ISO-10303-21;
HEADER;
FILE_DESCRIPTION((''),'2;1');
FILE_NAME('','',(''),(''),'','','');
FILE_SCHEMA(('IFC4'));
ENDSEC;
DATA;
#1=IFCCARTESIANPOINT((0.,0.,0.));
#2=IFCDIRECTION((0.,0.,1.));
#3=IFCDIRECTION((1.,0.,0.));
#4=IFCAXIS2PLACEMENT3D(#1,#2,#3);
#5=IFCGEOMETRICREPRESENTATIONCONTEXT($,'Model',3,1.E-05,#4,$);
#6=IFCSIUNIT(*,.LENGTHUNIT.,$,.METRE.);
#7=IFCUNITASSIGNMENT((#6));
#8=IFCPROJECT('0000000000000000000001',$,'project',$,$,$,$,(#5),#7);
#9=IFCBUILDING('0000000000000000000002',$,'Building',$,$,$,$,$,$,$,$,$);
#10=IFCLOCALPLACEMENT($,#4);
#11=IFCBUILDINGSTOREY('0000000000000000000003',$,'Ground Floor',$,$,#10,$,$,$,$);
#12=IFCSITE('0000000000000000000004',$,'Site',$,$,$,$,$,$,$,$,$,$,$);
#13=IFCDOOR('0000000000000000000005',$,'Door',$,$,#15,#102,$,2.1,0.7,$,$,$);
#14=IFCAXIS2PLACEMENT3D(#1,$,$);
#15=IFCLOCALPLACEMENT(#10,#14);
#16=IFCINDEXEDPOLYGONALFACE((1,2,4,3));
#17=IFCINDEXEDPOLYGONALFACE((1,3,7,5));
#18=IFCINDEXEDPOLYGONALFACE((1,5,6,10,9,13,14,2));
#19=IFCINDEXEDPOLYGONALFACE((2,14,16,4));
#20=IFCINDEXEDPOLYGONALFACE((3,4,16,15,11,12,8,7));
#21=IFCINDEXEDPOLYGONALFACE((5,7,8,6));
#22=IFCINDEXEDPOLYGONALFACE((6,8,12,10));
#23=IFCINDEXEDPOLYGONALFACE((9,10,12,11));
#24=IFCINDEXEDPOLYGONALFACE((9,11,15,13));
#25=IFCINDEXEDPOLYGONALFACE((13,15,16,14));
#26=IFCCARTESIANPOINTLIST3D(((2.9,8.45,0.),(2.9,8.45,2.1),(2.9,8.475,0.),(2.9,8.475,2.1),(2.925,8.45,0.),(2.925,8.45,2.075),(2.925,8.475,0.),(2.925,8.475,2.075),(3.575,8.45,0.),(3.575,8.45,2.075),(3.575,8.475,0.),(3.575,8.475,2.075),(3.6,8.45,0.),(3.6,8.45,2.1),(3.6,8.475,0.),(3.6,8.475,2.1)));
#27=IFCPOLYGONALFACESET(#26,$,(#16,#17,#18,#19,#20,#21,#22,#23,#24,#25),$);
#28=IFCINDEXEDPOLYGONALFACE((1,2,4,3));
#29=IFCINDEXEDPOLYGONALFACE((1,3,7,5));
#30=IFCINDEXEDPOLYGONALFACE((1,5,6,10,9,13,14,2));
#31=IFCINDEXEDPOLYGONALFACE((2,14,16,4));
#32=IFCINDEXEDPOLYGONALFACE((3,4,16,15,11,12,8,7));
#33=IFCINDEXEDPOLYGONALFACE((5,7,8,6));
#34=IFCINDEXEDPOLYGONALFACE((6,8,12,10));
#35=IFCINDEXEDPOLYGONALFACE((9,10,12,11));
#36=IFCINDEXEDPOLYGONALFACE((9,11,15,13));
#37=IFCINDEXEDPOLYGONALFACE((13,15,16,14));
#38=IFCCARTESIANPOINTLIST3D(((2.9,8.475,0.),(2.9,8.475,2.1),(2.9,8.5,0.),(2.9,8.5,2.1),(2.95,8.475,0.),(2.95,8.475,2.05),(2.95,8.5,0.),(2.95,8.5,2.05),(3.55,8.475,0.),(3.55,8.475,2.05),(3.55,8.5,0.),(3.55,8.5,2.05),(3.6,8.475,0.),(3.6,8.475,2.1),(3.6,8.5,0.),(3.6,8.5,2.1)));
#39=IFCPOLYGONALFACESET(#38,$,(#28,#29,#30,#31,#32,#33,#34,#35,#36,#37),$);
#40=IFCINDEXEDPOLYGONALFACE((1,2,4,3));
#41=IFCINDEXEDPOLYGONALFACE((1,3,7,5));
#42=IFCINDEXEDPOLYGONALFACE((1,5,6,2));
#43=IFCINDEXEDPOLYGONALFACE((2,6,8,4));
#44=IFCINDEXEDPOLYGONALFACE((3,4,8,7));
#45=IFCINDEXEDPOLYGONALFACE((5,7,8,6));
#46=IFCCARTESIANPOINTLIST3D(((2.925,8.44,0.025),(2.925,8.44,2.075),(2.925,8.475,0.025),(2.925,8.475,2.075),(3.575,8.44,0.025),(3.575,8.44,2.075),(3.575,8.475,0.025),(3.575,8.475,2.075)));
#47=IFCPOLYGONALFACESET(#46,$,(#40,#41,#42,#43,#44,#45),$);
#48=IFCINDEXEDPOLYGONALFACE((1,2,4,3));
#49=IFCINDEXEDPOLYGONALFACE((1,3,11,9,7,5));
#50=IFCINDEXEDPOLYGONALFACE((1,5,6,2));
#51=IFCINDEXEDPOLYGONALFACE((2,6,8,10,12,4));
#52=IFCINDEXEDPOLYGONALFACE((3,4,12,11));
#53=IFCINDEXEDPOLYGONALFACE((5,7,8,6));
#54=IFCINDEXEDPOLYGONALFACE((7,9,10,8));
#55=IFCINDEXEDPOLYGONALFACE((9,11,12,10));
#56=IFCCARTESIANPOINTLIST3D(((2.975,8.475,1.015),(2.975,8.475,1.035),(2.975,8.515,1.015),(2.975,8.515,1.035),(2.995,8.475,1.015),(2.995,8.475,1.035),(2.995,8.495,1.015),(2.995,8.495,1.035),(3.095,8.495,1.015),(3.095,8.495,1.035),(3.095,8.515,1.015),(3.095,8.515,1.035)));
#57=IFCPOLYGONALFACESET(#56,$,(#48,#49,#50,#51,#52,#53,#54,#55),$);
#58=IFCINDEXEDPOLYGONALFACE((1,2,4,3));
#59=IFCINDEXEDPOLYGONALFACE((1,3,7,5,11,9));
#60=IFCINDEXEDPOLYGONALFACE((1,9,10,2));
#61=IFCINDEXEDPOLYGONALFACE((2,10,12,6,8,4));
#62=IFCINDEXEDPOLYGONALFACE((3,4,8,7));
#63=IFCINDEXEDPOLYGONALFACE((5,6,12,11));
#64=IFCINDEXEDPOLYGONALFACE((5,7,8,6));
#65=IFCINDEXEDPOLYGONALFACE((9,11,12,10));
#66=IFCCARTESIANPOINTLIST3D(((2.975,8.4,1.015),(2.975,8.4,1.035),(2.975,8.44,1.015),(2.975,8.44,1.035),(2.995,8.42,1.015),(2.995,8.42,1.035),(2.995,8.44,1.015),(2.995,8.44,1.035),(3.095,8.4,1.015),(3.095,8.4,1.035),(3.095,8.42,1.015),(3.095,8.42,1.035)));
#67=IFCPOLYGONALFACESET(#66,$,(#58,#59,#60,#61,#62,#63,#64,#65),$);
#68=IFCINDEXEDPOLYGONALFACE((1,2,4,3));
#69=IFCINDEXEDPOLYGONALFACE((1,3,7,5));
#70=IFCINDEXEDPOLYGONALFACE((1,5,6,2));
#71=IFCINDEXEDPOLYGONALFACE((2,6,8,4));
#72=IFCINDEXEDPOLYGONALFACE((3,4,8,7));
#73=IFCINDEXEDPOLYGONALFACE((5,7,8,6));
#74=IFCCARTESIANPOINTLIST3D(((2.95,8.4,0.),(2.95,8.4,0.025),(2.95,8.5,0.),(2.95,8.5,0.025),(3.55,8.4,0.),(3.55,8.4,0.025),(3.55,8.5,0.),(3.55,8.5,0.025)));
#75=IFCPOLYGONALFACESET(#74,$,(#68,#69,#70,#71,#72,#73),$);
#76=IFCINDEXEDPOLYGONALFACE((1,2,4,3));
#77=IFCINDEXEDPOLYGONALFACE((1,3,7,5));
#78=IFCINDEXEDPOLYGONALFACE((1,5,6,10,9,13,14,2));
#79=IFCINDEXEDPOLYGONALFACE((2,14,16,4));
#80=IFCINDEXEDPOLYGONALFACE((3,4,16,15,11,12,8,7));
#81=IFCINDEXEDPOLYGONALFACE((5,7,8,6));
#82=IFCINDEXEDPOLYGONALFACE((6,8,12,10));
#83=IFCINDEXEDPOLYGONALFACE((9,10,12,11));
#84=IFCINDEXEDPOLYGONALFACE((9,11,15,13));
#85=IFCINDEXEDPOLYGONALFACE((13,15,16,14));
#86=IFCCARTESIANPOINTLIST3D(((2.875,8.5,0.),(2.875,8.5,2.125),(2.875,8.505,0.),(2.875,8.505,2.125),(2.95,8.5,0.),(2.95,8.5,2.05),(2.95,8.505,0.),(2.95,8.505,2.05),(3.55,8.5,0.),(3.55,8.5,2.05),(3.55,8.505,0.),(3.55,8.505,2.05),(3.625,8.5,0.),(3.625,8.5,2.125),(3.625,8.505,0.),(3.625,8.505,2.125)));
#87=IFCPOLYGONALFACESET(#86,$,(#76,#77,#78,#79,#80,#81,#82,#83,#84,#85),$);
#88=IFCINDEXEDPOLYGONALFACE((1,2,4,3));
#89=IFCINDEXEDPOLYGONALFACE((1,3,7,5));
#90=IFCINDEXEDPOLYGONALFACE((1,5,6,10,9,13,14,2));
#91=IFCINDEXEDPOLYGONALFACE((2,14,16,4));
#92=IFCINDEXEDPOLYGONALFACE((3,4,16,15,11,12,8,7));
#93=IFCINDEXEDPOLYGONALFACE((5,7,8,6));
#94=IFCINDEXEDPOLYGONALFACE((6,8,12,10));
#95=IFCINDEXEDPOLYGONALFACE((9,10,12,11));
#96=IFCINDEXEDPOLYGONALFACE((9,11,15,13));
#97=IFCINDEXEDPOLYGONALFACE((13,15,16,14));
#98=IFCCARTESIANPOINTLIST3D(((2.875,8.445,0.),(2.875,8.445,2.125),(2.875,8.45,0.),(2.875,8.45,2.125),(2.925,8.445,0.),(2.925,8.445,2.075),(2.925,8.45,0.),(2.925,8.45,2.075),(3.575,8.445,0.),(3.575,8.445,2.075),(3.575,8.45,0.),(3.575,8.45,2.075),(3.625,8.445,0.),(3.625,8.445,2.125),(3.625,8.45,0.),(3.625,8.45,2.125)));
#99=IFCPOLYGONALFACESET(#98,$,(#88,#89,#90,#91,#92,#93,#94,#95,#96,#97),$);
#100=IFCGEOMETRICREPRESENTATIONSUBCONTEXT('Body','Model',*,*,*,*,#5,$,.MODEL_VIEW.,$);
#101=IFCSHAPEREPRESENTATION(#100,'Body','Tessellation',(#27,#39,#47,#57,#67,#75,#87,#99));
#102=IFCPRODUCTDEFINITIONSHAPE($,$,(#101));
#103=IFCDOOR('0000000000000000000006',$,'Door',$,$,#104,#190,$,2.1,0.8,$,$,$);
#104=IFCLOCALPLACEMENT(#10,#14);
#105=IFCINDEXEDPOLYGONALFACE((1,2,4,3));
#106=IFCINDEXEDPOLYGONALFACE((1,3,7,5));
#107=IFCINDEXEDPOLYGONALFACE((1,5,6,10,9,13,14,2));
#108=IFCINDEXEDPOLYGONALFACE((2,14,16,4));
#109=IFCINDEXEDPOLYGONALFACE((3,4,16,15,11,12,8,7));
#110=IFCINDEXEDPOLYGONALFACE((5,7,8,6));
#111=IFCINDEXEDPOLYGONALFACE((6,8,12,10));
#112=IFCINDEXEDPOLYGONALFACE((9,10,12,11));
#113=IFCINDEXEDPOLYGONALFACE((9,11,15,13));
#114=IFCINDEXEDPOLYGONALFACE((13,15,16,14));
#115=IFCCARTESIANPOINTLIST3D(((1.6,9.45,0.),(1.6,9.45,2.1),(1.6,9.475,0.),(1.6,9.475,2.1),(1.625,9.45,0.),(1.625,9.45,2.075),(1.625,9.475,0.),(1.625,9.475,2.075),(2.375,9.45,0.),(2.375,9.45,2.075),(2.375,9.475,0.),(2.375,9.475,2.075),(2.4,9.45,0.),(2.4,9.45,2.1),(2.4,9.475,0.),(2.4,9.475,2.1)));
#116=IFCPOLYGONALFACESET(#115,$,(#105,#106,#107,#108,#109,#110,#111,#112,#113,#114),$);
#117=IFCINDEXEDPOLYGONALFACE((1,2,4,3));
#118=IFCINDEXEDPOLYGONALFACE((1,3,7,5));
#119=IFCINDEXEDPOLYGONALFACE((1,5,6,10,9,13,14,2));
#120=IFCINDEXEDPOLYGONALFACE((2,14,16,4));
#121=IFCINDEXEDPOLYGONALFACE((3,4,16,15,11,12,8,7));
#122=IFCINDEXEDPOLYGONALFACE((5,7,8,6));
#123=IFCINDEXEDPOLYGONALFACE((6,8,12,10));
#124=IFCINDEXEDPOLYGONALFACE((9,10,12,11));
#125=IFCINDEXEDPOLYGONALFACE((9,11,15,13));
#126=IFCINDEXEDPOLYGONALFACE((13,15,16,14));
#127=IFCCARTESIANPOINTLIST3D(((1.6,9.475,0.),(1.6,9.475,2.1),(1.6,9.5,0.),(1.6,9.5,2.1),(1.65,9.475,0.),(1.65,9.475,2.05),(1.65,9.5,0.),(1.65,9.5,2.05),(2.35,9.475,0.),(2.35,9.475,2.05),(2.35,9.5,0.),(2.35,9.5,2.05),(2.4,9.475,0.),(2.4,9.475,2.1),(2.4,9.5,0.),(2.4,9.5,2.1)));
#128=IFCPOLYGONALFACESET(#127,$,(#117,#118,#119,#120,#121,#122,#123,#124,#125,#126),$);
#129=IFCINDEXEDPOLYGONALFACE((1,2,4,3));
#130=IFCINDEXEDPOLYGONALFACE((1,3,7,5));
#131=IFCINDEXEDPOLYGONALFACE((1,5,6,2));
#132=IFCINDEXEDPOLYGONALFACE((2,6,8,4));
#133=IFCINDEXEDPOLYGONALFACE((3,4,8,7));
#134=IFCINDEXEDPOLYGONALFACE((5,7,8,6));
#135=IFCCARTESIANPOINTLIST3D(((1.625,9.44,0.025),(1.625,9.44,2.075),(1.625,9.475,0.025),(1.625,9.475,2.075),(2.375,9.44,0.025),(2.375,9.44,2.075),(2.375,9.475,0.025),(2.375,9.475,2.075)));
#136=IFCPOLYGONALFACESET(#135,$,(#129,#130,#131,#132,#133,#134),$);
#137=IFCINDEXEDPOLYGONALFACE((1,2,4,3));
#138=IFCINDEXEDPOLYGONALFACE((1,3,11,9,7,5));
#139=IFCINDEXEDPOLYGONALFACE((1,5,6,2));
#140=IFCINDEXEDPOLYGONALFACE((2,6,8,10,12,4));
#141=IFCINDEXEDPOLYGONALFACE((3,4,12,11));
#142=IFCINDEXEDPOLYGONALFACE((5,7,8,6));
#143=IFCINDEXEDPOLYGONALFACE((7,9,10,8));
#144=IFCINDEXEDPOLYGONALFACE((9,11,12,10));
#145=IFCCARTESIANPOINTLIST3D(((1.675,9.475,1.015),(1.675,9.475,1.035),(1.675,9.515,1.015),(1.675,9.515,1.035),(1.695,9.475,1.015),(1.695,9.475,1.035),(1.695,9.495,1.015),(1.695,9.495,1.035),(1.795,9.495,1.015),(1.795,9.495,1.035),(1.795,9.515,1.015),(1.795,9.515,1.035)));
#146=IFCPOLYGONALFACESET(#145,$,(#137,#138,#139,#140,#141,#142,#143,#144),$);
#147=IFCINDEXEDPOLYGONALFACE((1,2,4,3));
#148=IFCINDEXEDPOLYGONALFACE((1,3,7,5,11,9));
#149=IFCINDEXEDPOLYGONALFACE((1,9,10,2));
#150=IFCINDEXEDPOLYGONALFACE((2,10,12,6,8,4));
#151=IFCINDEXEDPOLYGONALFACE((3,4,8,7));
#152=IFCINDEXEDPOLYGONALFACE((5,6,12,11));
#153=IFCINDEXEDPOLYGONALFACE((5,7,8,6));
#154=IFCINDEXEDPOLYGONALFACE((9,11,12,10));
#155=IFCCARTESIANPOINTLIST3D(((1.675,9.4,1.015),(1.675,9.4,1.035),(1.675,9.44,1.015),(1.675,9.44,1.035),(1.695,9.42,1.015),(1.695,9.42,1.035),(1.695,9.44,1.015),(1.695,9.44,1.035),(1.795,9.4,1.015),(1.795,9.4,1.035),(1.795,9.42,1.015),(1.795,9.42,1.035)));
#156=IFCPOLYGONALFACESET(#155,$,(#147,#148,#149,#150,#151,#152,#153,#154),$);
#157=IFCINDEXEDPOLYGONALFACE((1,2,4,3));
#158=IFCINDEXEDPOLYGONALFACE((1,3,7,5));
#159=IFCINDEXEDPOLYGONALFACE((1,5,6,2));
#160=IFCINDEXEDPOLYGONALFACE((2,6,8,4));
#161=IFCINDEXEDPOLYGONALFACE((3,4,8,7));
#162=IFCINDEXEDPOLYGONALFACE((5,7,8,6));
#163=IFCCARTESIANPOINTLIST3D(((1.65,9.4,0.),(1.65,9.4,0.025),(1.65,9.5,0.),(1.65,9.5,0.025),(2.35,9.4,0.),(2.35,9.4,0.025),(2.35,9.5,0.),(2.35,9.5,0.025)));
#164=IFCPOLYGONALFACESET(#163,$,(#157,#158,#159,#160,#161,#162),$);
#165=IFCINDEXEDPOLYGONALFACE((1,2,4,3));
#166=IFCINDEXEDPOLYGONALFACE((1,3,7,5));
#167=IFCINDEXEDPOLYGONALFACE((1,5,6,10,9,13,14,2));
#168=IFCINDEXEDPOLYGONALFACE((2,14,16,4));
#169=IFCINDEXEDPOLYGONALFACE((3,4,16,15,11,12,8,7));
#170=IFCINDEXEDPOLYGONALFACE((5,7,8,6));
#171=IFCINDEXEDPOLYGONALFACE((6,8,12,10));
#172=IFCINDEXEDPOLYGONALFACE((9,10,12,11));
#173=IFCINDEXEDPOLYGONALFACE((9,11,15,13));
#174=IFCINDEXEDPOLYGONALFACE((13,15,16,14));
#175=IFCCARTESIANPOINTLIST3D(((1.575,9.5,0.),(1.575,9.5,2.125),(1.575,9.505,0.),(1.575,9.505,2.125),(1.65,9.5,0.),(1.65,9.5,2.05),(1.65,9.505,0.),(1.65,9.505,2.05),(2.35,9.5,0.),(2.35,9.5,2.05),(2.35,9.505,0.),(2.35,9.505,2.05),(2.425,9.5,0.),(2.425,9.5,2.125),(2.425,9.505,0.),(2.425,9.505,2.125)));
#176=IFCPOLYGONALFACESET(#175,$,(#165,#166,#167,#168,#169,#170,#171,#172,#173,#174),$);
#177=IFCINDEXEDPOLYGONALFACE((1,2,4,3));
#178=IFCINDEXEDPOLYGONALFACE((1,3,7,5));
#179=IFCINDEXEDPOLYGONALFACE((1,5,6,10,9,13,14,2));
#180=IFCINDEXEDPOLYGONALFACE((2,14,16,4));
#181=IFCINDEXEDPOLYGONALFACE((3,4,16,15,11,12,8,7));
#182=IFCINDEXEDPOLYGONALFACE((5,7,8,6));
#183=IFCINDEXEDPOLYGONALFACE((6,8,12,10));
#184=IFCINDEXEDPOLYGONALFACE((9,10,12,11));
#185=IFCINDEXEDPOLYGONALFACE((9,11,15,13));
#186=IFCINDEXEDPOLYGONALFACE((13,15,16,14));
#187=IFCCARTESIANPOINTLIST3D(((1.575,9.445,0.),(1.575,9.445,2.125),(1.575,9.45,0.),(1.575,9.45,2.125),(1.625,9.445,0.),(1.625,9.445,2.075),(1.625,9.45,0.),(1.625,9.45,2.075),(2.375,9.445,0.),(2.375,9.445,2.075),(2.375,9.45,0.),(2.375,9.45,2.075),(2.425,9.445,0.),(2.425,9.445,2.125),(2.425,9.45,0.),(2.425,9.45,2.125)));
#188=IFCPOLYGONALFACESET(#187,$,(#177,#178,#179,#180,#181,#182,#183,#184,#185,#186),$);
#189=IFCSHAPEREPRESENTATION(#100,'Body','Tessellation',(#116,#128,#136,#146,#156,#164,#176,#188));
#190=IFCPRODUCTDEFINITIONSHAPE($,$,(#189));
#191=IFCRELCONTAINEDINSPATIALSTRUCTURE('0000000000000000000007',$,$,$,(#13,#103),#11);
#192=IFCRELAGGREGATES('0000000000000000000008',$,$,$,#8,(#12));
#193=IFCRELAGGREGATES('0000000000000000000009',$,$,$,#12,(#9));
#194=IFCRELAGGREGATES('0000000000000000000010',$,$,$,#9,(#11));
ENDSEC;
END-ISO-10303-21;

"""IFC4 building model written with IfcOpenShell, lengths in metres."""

from ifc_helpers import new_model, si_unit, frame, origin_with_axes, place, context, subcontext, project, spatial, line, indexed_curve, outline, extrude, element, save


model = new_model("IFC4")

# Units and contexts
model_context = context("Model", 3, precision=1e-05, world=origin_with_axes())
body_context = subcontext(model_context, "Body", "Model", "MODEL_VIEW")
ifc_project = project(units=[si_unit("LENGTHUNIT", "METRE")], contexts=[model_context])

# Site, building, storey
site = spatial("IfcSite", under=ifc_project, Name="Site")
building = spatial("IfcBuilding", under=site, Name="Building")
storey_placement = place(None, origin_with_axes())
storey = spatial("IfcBuildingStorey", under=building, at=storey_placement, Name="Ground Floor")

# Doors
door_1_placement = place(storey_placement, frame((3.6, 8.5, 0.0), z_axis=(0.0, 0.0, 1.0), x_axis=(-1.0, 0.0, 0.0)))
element("IfcDoor", 1, at=door_1_placement, inside=storey, Name="Door", OverallHeight=2.1, OverallWidth=0.7, context=body_context, shape_type="SweptSolid", body=[
    extrude(outline(indexed_curve([(0.0, 0.0), (0.0, 2.1), (0.7, 2.1), (0.7, 0.0), (0.675, 0.0), (0.675, 2.075), (0.025, 2.075), (0.025, 0.0)], segments=[line(1, 2, 3, 4, 5, 6, 7, 8, 1)])), frame((0.0, 0.025, 0.0), z_axis=(0.0, -1.0, 0.0), x_axis=(1.0, 0.0, 0.0)), (0.0, 0.0, -1.0), 0.025),
    extrude(outline(indexed_curve([(0.0, 0.0), (0.0, 2.1), (0.7, 2.1), (0.7, 0.0), (0.65, 0.0), (0.65, 2.05), (0.05, 2.05), (0.05, 0.0)], segments=[line(1, 2, 3, 4, 5, 6, 7, 8, 1)])), frame((0.0, 0.0, 0.0), z_axis=(0.0, -1.0, 0.0), x_axis=(1.0, 0.0, 0.0)), (0.0, 0.0, -1.0), 0.025),
    extrude(outline(indexed_curve([(0.0, 0.0), (0.65, 0.0), (0.65, 0.035), (0.0, 0.035)], segments=[line(1, 2, 3, 4, 1)])), frame((0.025, 0.025, 0.025), z_axis=(0.0, 0.0, 1.0), x_axis=(1.0, 0.0, 0.0)), (0.0, 0.0, 1.0), 2.05),
    extrude(outline(indexed_curve([(0.0, 0.0), (0.0, -0.04), (-0.12, -0.04), (-0.12, -0.02), (-0.02, -0.02), (-0.02, 0.0)], segments=[line(1, 2, 3, 4, 5, 6, 1)])), frame((0.625, 0.025, 1.015), z_axis=(0.0, 0.0, 1.0), x_axis=(1.0, 0.0, 0.0)), (0.0, 0.0, 1.0), 0.02),
    extrude(outline(indexed_curve([(0.0, 0.0), (0.0, 0.04), (-0.12, 0.04), (-0.12, 0.02), (-0.02, 0.02), (-0.02, 0.0)], segments=[line(1, 2, 3, 4, 5, 6, 1)])), frame((0.625, 0.06, 1.015), z_axis=(0.0, 0.0, 1.0), x_axis=(1.0, 0.0, 0.0)), (0.0, 0.0, 1.0), 0.02),
    extrude(outline(indexed_curve([(0.0, 0.0), (0.6, 0.0), (0.6, 0.1), (0.0, 0.1)], segments=[line(1, 2, 3, 4, 1)])), frame((0.05, 0.0, 0.0), z_axis=(0.0, 0.0, 1.0), x_axis=(1.0, 0.0, 0.0)), (0.0, 0.0, 1.0), 0.025),
    extrude(outline(indexed_curve([(0.0, 0.0), (0.0, 2.125), (0.75, 2.125), (0.75, 0.0), (0.675, 0.0), (0.675, 2.05), (0.075, 2.05), (0.075, 0.0)], segments=[line(1, 2, 3, 4, 5, 6, 7, 8, 1)])), frame((-0.025, -0.005, 0.0), z_axis=(0.0, -1.0, 0.0), x_axis=(1.0, 0.0, 0.0)), (0.0, 0.0, -1.0), 0.005),
    extrude(outline(indexed_curve([(0.0, 0.0), (0.0, 2.125), (0.75, 2.125), (0.75, 0.0), (0.7, 0.0), (0.7, 2.075), (0.05, 2.075), (0.05, 0.0)], segments=[line(1, 2, 3, 4, 5, 6, 7, 8, 1)])), frame((-0.025, 0.05, 0.0), z_axis=(0.0, -1.0, 0.0), x_axis=(1.0, 0.0, 0.0)), (0.0, 0.0, -1.0), 0.005),
])
door_2_placement = place(storey_placement, frame((2.4, 9.5, 0.0), z_axis=(0.0, 0.0, 1.0), x_axis=(-1.0, 0.0, 0.0)))
element("IfcDoor", 2, at=door_2_placement, inside=storey, Name="Door", OverallHeight=2.1, OverallWidth=0.8, context=body_context, shape_type="SweptSolid", body=[
    extrude(outline(indexed_curve([(0.0, 0.0), (0.0, 2.1), (0.8, 2.1), (0.8, 0.0), (0.775, 0.0), (0.775, 2.075), (0.025, 2.075), (0.025, 0.0)], segments=[line(1, 2, 3, 4, 5, 6, 7, 8, 1)])), frame((0.0, 0.025, 0.0), z_axis=(0.0, -1.0, 0.0), x_axis=(1.0, 0.0, 0.0)), (0.0, 0.0, -1.0), 0.025),
    extrude(outline(indexed_curve([(0.0, 0.0), (0.0, 2.1), (0.8, 2.1), (0.8, 0.0), (0.75, 0.0), (0.75, 2.05), (0.05, 2.05), (0.05, 0.0)], segments=[line(1, 2, 3, 4, 5, 6, 7, 8, 1)])), frame((0.0, 0.0, 0.0), z_axis=(0.0, -1.0, 0.0), x_axis=(1.0, 0.0, 0.0)), (0.0, 0.0, -1.0), 0.025),
    extrude(outline(indexed_curve([(0.0, 0.0), (0.75, 0.0), (0.75, 0.035), (0.0, 0.035)], segments=[line(1, 2, 3, 4, 1)])), frame((0.025, 0.025, 0.025), z_axis=(0.0, 0.0, 1.0), x_axis=(1.0, 0.0, 0.0)), (0.0, 0.0, 1.0), 2.05),
    extrude(outline(indexed_curve([(0.0, 0.0), (0.0, -0.04), (-0.12, -0.04), (-0.12, -0.02), (-0.02, -0.02), (-0.02, 0.0)], segments=[line(1, 2, 3, 4, 5, 6, 1)])), frame((0.725, 0.025, 1.015), z_axis=(0.0, 0.0, 1.0), x_axis=(1.0, 0.0, 0.0)), (0.0, 0.0, 1.0), 0.02),
    extrude(outline(indexed_curve([(0.0, 0.0), (0.0, 0.04), (-0.12, 0.04), (-0.12, 0.02), (-0.02, 0.02), (-0.02, 0.0)], segments=[line(1, 2, 3, 4, 5, 6, 1)])), frame((0.725, 0.06, 1.015), z_axis=(0.0, 0.0, 1.0), x_axis=(1.0, 0.0, 0.0)), (0.0, 0.0, 1.0), 0.02),
    extrude(outline(indexed_curve([(0.0, 0.0), (0.7, 0.0), (0.7, 0.1), (0.0, 0.1)], segments=[line(1, 2, 3, 4, 1)])), frame((0.05, 0.0, 0.0), z_axis=(0.0, 0.0, 1.0), x_axis=(1.0, 0.0, 0.0)), (0.0, 0.0, 1.0), 0.025),
    extrude(outline(indexed_curve([(0.0, 0.0), (0.0, 2.125), (0.85, 2.125), (0.85, 0.0), (0.775, 0.0), (0.775, 2.05), (0.075, 2.05), (0.075, 0.0)], segments=[line(1, 2, 3, 4, 5, 6, 7, 8, 1)])), frame((-0.025, -0.005, 0.0), z_axis=(0.0, -1.0, 0.0), x_axis=(1.0, 0.0, 0.0)), (0.0, 0.0, -1.0), 0.005),
    extrude(outline(indexed_curve([(0.0, 0.0), (0.0, 2.125), (0.85, 2.125), (0.85, 0.0), (0.8, 0.0), (0.8, 2.075), (0.05, 2.075), (0.05, 0.0)], segments=[line(1, 2, 3, 4, 5, 6, 7, 8, 1)])), frame((-0.025, 0.05, 0.0), z_axis=(0.0, -1.0, 0.0), x_axis=(1.0, 0.0, 0.0)), (0.0, 0.0, -1.0), 0.005),
])

save(model, "model.ifc")
